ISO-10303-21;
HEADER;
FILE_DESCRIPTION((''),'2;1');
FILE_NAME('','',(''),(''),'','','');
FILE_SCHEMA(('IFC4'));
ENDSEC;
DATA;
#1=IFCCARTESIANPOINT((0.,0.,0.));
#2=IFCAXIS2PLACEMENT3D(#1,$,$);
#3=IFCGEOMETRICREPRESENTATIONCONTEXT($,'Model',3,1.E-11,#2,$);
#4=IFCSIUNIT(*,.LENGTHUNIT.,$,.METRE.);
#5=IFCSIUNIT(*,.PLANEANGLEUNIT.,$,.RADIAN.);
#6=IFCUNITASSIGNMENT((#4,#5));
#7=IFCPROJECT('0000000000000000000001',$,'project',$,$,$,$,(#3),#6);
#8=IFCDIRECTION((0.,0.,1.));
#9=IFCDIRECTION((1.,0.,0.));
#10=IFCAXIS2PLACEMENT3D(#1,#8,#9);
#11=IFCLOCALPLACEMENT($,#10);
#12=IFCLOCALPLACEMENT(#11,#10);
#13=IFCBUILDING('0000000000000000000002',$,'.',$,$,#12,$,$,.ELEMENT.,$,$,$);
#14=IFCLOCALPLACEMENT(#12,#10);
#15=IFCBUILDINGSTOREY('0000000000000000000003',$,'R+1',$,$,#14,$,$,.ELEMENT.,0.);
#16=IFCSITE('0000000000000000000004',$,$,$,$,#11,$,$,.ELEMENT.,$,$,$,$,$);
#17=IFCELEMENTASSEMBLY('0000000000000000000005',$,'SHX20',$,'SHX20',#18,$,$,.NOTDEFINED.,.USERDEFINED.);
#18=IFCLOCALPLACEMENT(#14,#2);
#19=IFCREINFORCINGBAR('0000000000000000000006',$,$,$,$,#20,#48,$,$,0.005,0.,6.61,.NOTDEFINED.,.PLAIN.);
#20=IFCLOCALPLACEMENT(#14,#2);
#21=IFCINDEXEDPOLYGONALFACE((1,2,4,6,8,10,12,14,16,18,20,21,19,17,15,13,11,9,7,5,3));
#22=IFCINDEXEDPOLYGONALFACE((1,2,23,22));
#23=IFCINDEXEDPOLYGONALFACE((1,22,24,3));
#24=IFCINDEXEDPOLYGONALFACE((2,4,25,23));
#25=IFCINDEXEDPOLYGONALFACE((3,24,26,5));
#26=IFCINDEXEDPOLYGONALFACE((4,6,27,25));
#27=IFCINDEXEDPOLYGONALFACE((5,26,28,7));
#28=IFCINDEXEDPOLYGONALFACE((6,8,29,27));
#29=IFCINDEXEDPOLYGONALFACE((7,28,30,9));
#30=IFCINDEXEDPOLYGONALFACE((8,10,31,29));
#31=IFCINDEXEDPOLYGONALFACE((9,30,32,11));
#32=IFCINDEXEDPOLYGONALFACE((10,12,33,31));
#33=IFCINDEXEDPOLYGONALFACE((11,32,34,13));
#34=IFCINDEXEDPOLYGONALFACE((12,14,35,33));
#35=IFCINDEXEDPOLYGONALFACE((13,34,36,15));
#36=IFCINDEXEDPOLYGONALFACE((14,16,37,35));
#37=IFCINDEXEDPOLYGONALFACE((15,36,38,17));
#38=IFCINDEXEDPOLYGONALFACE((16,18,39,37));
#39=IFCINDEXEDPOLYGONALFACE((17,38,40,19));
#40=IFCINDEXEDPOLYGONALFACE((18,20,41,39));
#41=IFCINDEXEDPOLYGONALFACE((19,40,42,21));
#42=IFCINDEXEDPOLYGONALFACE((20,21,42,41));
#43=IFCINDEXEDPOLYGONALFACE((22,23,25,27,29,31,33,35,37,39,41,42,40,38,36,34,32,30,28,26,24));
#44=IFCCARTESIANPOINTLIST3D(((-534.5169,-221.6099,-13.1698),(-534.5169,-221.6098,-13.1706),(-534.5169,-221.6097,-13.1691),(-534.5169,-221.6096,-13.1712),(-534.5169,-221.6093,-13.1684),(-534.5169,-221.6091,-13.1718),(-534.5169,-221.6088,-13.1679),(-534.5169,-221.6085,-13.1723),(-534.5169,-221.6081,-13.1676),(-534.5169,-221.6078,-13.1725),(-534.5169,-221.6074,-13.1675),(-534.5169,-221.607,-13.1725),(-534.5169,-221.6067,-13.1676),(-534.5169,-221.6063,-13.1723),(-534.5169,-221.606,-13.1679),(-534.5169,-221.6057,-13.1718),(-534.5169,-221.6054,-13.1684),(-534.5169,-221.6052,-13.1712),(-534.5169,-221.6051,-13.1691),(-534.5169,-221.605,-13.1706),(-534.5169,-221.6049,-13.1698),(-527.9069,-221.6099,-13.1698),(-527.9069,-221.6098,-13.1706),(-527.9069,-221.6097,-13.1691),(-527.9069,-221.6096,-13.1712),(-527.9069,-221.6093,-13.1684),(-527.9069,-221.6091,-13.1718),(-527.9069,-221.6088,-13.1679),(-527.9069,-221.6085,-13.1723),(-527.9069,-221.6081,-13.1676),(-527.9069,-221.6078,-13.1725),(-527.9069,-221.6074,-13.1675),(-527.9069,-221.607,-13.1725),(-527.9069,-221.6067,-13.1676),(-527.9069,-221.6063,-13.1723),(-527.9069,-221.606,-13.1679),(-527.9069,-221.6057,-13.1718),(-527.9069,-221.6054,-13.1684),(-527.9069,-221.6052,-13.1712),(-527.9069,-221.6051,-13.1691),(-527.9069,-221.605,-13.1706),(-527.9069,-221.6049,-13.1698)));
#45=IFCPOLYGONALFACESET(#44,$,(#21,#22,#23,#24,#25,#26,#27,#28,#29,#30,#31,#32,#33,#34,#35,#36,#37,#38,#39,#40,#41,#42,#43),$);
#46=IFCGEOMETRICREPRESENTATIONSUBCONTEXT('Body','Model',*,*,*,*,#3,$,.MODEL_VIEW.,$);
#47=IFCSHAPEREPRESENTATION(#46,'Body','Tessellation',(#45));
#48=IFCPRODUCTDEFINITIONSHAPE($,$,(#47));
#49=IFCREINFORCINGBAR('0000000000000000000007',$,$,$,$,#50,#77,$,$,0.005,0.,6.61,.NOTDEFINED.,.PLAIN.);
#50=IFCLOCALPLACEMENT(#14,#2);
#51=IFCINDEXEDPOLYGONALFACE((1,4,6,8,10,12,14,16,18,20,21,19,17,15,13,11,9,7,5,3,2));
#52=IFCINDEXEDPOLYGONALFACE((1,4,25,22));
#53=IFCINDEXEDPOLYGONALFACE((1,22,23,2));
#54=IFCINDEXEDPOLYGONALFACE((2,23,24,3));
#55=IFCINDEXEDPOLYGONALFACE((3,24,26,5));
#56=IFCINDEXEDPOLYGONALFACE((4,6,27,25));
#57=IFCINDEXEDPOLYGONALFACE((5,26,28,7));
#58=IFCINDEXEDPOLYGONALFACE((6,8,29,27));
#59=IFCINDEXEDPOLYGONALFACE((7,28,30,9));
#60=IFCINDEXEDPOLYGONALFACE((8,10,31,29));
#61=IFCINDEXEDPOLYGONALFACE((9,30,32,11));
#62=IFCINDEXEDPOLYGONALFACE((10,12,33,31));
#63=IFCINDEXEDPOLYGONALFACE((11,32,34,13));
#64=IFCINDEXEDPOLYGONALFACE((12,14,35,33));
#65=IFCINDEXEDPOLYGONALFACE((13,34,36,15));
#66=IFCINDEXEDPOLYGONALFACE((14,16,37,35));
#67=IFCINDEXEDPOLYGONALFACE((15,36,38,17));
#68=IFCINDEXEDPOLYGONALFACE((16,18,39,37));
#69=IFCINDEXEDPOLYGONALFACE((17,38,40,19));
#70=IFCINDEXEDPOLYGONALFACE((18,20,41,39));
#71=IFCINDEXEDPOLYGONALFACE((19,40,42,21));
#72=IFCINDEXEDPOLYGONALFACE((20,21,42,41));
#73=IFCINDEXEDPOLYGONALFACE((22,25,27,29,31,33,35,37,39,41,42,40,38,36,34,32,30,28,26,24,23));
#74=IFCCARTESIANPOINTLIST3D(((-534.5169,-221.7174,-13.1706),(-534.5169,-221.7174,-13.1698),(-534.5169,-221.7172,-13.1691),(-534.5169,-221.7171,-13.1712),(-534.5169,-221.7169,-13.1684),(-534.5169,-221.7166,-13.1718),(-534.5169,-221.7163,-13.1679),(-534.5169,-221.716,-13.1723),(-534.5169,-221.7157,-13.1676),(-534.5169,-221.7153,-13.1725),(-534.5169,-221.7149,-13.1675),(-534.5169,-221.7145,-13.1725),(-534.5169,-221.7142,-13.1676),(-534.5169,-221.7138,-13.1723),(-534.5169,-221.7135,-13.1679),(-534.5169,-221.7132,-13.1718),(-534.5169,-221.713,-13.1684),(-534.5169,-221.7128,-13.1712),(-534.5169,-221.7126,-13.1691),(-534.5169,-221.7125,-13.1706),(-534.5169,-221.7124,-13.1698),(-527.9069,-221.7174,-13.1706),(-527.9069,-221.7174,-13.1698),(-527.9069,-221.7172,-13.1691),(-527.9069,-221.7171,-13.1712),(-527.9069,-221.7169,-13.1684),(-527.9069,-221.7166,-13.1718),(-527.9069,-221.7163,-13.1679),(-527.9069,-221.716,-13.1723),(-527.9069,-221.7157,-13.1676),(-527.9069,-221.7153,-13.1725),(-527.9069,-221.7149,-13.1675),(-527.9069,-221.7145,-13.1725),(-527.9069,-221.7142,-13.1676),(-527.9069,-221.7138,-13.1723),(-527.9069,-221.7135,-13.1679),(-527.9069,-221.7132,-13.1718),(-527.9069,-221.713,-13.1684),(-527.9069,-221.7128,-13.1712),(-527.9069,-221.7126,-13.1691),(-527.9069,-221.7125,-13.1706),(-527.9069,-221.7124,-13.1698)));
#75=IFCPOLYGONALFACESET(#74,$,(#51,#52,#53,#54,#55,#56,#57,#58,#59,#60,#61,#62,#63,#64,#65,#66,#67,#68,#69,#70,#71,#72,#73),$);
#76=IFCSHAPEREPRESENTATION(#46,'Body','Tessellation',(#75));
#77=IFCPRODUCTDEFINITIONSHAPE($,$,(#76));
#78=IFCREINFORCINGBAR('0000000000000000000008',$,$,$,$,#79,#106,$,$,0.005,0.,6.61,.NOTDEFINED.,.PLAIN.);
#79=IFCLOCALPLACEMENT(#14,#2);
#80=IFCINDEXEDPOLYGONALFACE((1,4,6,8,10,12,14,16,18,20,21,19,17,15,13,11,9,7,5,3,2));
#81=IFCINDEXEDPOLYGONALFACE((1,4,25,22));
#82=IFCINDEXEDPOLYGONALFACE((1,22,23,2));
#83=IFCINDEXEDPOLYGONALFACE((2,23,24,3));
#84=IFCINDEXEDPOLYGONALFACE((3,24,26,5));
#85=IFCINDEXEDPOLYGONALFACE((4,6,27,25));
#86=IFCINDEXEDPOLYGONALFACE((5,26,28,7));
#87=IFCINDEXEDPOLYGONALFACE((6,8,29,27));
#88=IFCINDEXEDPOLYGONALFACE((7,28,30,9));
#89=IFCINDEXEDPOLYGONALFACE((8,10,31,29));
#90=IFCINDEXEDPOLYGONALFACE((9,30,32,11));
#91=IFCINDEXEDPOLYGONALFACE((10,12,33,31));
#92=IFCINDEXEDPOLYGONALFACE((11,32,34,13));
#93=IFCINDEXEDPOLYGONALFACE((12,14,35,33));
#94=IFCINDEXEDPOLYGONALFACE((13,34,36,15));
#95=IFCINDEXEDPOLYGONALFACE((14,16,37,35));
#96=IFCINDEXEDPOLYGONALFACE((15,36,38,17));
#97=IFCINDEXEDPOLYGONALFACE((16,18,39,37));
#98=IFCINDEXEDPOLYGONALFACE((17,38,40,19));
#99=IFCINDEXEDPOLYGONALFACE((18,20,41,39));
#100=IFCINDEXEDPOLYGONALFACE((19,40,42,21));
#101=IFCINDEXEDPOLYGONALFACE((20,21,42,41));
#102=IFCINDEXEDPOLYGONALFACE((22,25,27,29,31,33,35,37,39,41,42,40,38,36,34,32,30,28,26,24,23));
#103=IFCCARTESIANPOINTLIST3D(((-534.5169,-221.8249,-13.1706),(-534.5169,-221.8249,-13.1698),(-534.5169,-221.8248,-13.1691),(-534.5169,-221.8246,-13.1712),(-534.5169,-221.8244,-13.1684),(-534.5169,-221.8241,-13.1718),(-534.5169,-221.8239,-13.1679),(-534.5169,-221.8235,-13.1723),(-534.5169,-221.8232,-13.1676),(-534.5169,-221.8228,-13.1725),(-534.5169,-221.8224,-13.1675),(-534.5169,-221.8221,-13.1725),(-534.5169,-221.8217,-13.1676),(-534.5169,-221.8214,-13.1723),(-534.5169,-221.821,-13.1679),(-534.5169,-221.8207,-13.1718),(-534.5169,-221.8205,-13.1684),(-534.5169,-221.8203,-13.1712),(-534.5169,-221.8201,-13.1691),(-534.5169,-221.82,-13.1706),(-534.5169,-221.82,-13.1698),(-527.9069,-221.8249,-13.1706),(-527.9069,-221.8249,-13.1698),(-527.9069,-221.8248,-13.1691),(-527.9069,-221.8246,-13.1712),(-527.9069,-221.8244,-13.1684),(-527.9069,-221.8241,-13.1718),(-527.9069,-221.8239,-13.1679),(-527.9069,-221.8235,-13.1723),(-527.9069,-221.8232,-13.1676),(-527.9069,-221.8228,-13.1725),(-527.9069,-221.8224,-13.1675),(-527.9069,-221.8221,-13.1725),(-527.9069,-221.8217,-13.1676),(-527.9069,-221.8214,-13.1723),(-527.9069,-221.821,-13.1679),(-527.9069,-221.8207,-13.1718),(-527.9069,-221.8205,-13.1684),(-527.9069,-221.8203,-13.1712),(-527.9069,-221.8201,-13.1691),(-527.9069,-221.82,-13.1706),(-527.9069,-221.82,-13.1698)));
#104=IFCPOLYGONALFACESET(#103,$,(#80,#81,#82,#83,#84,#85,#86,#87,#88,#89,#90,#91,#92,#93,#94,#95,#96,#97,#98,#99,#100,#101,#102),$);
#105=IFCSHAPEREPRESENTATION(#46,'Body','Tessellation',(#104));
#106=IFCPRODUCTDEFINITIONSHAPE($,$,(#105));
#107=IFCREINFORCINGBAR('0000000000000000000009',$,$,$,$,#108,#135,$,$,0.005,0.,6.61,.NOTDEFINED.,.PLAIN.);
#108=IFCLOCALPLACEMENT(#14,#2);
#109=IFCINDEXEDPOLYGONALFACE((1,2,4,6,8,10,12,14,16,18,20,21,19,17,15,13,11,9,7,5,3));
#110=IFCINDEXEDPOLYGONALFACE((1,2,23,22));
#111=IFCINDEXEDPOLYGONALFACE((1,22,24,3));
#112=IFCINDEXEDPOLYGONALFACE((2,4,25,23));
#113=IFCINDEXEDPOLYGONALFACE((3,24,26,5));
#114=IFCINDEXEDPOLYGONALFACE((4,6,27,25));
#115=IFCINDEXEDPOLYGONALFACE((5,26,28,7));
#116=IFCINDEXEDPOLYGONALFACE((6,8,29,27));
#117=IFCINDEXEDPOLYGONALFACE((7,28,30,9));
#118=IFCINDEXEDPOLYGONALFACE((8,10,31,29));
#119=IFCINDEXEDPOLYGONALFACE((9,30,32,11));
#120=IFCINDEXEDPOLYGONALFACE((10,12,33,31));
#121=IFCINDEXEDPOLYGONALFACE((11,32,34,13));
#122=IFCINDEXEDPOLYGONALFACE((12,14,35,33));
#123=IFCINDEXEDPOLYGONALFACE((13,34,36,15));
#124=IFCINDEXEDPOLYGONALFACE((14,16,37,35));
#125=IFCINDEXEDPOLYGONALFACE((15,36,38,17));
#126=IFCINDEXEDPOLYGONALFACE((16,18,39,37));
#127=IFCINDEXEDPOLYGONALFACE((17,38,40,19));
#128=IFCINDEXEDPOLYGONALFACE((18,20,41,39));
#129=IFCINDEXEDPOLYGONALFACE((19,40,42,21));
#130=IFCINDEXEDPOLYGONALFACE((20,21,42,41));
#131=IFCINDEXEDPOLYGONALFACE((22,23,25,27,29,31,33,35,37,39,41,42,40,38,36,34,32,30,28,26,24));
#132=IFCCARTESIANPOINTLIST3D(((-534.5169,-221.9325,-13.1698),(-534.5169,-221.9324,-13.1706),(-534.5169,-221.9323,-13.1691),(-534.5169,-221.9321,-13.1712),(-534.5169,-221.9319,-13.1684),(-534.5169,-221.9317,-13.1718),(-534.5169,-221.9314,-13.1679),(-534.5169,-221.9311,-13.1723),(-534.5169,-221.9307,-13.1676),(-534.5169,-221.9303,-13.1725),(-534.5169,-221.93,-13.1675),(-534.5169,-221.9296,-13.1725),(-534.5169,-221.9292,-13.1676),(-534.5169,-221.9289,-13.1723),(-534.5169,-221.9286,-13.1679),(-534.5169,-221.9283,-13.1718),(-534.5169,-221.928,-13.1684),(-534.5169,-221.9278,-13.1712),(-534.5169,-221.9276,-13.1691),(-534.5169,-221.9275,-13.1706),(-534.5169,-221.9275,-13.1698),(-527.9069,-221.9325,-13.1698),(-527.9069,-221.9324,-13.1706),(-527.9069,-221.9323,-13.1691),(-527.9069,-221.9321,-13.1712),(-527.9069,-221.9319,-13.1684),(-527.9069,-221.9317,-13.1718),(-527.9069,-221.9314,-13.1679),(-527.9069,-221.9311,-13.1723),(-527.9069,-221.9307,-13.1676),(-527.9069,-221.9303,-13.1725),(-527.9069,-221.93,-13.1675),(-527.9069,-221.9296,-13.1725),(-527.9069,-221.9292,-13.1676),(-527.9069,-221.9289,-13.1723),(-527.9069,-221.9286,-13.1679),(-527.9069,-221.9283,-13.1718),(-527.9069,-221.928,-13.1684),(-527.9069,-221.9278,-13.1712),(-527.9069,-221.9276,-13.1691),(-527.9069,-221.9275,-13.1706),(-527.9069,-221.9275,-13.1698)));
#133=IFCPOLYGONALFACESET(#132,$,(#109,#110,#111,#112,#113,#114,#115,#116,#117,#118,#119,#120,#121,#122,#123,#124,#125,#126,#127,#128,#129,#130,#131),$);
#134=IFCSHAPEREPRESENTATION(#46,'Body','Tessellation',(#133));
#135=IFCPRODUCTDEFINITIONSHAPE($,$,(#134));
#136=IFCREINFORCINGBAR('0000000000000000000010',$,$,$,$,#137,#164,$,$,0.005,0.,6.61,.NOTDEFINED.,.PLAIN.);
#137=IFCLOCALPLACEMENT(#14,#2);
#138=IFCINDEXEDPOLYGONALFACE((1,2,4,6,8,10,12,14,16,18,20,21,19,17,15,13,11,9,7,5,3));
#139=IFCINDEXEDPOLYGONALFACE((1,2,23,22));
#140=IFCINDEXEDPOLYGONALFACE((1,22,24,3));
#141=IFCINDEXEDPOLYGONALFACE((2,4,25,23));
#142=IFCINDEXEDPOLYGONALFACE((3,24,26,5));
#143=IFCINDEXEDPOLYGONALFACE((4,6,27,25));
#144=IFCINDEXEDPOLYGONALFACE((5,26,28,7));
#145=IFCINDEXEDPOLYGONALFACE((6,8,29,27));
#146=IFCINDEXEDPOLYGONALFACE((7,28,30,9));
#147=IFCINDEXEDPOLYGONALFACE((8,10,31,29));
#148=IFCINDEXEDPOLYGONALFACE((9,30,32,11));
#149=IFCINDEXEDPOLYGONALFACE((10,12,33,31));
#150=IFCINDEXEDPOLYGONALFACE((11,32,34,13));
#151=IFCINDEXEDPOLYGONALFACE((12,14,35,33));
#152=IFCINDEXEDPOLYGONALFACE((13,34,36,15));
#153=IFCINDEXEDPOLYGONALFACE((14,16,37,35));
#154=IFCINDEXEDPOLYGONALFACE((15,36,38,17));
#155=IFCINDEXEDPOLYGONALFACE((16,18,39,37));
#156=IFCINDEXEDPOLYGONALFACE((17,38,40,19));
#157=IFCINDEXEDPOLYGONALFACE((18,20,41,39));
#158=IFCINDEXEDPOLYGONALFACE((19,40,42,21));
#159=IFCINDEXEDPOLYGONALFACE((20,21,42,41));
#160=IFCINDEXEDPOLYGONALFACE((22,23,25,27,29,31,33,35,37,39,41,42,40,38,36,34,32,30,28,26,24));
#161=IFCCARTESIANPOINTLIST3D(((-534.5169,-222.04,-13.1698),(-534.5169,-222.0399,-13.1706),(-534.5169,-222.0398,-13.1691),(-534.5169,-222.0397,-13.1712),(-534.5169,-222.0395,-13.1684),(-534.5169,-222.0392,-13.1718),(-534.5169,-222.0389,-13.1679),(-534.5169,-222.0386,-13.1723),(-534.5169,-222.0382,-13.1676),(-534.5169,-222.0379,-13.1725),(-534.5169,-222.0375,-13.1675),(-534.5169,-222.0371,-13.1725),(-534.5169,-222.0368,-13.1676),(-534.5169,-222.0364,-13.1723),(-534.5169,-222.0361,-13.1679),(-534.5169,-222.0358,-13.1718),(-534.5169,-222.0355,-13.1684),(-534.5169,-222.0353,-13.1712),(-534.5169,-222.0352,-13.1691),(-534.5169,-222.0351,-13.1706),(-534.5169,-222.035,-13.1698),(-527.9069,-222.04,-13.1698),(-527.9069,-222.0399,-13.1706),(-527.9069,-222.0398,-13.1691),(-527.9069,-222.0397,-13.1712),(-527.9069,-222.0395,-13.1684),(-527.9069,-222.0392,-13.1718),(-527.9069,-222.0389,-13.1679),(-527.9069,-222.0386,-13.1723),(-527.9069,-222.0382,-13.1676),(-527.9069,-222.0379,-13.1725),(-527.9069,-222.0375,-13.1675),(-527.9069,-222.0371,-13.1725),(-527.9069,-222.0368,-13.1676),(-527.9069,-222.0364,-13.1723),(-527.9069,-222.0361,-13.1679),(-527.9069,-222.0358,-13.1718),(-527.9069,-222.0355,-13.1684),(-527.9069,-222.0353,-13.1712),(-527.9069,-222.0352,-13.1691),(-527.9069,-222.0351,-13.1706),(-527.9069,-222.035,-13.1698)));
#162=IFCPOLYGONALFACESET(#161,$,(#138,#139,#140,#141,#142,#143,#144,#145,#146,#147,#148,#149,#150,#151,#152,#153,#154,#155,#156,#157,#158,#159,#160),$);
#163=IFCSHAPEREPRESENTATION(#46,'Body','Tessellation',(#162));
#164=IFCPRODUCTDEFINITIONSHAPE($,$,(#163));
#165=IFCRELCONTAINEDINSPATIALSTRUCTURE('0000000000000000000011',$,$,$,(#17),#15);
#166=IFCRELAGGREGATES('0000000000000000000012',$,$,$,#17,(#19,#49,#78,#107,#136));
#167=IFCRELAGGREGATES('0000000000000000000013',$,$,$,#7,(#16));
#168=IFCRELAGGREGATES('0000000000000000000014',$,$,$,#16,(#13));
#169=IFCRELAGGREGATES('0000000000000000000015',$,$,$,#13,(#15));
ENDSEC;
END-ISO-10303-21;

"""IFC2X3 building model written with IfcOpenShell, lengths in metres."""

from ifc_helpers import new_model, entity, si_unit, origin, origin_with_axes, place, context, subcontext, project, spatial, shape, element, aggregate, save


model = new_model("IFC2X3")

# Units and contexts
model_context = context("Model", 3, precision=1e-11, world=origin())
body_context = subcontext(model_context, "Body", "Model", "MODEL_VIEW")
ifc_project = project(units=[si_unit("LENGTHUNIT", "METRE"), si_unit("PLANEANGLEUNIT", "RADIAN")], contexts=[model_context])

# Site, building, storey
site_placement = place(None, origin_with_axes())
site = spatial("IfcSite", under=ifc_project, at=site_placement, CompositionType="ELEMENT")
building_placement = place(site_placement, origin_with_axes())
building = spatial("IfcBuilding", under=site, at=building_placement, Name=".", CompositionType="ELEMENT")
storey_placement = place(building_placement, origin_with_axes())
storey = spatial("IfcBuildingStorey", under=building, at=storey_placement, Name="R+1", CompositionType="ELEMENT", Elevation=0.0)

# Element assembly, reinforcing bars
assembly_1_placement = place(storey_placement, origin_with_axes())
assembly_1 = element("IfcElementAssembly", 1, at=assembly_1_placement, inside=storey, Name="SHX20", ObjectType="SHX20", AssemblyPlace="NOTDEFINED", PredefinedType="USERDEFINED")
reinforcing_bar_1_placement = place(assembly_1_placement, origin_with_axes())
reinforcing_bar_1 = element("IfcReinforcingBar", 2, at=reinforcing_bar_1_placement, BarLength=6.61, BarRole="NOTDEFINED", BarSurface="PLAIN", CrossSectionArea=0.0, NominalDiameter=0.005, shapes=[
    shape(body_context, "Body", "AdvancedSweptSolid", [entity("IfcSweptDiskSolid", entity("IfcPolyline", [entity("IfcCartesianPoint", [527.9069, 221.6074, 13.17]), entity("IfcCartesianPoint", [534.5169, 221.6074, 13.17])]), 0.0025, None, 0.0, 6.61)]),
    shape(body_context, "Body", "AdvancedSweptSolid", [entity("IfcSweptDiskSolid", entity("IfcPolyline", [entity("IfcCartesianPoint", [527.9069, 221.6074, 13.17]), entity("IfcCartesianPoint", [534.5169, 221.6074, 13.17])]), 0.0025, None, 0.0, 6.61)]),
])
reinforcing_bar_2_placement = place(assembly_1_placement, origin_with_axes())
reinforcing_bar_2 = element("IfcReinforcingBar", 3, at=reinforcing_bar_2_placement, BarLength=6.61, BarRole="NOTDEFINED", BarSurface="PLAIN", CrossSectionArea=0.0, NominalDiameter=0.005, shapes=[
    shape(body_context, "Body", "AdvancedSweptSolid", [entity("IfcSweptDiskSolid", entity("IfcPolyline", [entity("IfcCartesianPoint", [527.9069, 221.7149, 13.17]), entity("IfcCartesianPoint", [534.5169, 221.7149, 13.17])]), 0.0025, None, 0.0, 6.61)]),
    shape(body_context, "Body", "AdvancedSweptSolid", [entity("IfcSweptDiskSolid", entity("IfcPolyline", [entity("IfcCartesianPoint", [527.9069, 221.7149, 13.17]), entity("IfcCartesianPoint", [534.5169, 221.7149, 13.17])]), 0.0025, None, 0.0, 6.61)]),
])
reinforcing_bar_3_placement = place(assembly_1_placement, origin_with_axes())
reinforcing_bar_3 = element("IfcReinforcingBar", 4, at=reinforcing_bar_3_placement, BarLength=6.61, BarRole="NOTDEFINED", BarSurface="PLAIN", CrossSectionArea=0.0, NominalDiameter=0.005, shapes=[
    shape(body_context, "Body", "AdvancedSweptSolid", [entity("IfcSweptDiskSolid", entity("IfcPolyline", [entity("IfcCartesianPoint", [527.9069, 221.8224, 13.17]), entity("IfcCartesianPoint", [534.5169, 221.8224, 13.17])]), 0.0025, None, 0.0, 6.61)]),
    shape(body_context, "Body", "AdvancedSweptSolid", [entity("IfcSweptDiskSolid", entity("IfcPolyline", [entity("IfcCartesianPoint", [527.9069, 221.8224, 13.17]), entity("IfcCartesianPoint", [534.5169, 221.8224, 13.17])]), 0.0025, None, 0.0, 6.61)]),
])
reinforcing_bar_4_placement = place(assembly_1_placement, origin_with_axes())
reinforcing_bar_4 = element("IfcReinforcingBar", 5, at=reinforcing_bar_4_placement, BarLength=6.61, BarRole="NOTDEFINED", BarSurface="PLAIN", CrossSectionArea=0.0, NominalDiameter=0.005, shapes=[
    shape(body_context, "Body", "AdvancedSweptSolid", [entity("IfcSweptDiskSolid", entity("IfcPolyline", [entity("IfcCartesianPoint", [527.9069, 221.93, 13.17]), entity("IfcCartesianPoint", [534.5169, 221.93, 13.17])]), 0.0025, None, 0.0, 6.61)]),
    shape(body_context, "Body", "AdvancedSweptSolid", [entity("IfcSweptDiskSolid", entity("IfcPolyline", [entity("IfcCartesianPoint", [527.9069, 221.93, 13.17]), entity("IfcCartesianPoint", [534.5169, 221.93, 13.17])]), 0.0025, None, 0.0, 6.61)]),
])
reinforcing_bar_5_placement = place(assembly_1_placement, origin_with_axes())
reinforcing_bar_5 = element("IfcReinforcingBar", 6, at=reinforcing_bar_5_placement, BarLength=6.61, BarRole="NOTDEFINED", BarSurface="PLAIN", CrossSectionArea=0.0, NominalDiameter=0.005, shapes=[
    shape(body_context, "Body", "AdvancedSweptSolid", [entity("IfcSweptDiskSolid", entity("IfcPolyline", [entity("IfcCartesianPoint", [527.9069, 222.0375, 13.17]), entity("IfcCartesianPoint", [534.5169, 222.0375, 13.17])]), 0.0025, None, 0.0, 6.61)]),
    shape(body_context, "Body", "AdvancedSweptSolid", [entity("IfcSweptDiskSolid", entity("IfcPolyline", [entity("IfcCartesianPoint", [527.9069, 222.0375, 13.17]), entity("IfcCartesianPoint", [534.5169, 222.0375, 13.17])]), 0.0025, None, 0.0, 6.61)]),
])
aggregate(assembly_1, [reinforcing_bar_1, reinforcing_bar_2, reinforcing_bar_3, reinforcing_bar_4, reinforcing_bar_5])

save(model, "model.ifc")
